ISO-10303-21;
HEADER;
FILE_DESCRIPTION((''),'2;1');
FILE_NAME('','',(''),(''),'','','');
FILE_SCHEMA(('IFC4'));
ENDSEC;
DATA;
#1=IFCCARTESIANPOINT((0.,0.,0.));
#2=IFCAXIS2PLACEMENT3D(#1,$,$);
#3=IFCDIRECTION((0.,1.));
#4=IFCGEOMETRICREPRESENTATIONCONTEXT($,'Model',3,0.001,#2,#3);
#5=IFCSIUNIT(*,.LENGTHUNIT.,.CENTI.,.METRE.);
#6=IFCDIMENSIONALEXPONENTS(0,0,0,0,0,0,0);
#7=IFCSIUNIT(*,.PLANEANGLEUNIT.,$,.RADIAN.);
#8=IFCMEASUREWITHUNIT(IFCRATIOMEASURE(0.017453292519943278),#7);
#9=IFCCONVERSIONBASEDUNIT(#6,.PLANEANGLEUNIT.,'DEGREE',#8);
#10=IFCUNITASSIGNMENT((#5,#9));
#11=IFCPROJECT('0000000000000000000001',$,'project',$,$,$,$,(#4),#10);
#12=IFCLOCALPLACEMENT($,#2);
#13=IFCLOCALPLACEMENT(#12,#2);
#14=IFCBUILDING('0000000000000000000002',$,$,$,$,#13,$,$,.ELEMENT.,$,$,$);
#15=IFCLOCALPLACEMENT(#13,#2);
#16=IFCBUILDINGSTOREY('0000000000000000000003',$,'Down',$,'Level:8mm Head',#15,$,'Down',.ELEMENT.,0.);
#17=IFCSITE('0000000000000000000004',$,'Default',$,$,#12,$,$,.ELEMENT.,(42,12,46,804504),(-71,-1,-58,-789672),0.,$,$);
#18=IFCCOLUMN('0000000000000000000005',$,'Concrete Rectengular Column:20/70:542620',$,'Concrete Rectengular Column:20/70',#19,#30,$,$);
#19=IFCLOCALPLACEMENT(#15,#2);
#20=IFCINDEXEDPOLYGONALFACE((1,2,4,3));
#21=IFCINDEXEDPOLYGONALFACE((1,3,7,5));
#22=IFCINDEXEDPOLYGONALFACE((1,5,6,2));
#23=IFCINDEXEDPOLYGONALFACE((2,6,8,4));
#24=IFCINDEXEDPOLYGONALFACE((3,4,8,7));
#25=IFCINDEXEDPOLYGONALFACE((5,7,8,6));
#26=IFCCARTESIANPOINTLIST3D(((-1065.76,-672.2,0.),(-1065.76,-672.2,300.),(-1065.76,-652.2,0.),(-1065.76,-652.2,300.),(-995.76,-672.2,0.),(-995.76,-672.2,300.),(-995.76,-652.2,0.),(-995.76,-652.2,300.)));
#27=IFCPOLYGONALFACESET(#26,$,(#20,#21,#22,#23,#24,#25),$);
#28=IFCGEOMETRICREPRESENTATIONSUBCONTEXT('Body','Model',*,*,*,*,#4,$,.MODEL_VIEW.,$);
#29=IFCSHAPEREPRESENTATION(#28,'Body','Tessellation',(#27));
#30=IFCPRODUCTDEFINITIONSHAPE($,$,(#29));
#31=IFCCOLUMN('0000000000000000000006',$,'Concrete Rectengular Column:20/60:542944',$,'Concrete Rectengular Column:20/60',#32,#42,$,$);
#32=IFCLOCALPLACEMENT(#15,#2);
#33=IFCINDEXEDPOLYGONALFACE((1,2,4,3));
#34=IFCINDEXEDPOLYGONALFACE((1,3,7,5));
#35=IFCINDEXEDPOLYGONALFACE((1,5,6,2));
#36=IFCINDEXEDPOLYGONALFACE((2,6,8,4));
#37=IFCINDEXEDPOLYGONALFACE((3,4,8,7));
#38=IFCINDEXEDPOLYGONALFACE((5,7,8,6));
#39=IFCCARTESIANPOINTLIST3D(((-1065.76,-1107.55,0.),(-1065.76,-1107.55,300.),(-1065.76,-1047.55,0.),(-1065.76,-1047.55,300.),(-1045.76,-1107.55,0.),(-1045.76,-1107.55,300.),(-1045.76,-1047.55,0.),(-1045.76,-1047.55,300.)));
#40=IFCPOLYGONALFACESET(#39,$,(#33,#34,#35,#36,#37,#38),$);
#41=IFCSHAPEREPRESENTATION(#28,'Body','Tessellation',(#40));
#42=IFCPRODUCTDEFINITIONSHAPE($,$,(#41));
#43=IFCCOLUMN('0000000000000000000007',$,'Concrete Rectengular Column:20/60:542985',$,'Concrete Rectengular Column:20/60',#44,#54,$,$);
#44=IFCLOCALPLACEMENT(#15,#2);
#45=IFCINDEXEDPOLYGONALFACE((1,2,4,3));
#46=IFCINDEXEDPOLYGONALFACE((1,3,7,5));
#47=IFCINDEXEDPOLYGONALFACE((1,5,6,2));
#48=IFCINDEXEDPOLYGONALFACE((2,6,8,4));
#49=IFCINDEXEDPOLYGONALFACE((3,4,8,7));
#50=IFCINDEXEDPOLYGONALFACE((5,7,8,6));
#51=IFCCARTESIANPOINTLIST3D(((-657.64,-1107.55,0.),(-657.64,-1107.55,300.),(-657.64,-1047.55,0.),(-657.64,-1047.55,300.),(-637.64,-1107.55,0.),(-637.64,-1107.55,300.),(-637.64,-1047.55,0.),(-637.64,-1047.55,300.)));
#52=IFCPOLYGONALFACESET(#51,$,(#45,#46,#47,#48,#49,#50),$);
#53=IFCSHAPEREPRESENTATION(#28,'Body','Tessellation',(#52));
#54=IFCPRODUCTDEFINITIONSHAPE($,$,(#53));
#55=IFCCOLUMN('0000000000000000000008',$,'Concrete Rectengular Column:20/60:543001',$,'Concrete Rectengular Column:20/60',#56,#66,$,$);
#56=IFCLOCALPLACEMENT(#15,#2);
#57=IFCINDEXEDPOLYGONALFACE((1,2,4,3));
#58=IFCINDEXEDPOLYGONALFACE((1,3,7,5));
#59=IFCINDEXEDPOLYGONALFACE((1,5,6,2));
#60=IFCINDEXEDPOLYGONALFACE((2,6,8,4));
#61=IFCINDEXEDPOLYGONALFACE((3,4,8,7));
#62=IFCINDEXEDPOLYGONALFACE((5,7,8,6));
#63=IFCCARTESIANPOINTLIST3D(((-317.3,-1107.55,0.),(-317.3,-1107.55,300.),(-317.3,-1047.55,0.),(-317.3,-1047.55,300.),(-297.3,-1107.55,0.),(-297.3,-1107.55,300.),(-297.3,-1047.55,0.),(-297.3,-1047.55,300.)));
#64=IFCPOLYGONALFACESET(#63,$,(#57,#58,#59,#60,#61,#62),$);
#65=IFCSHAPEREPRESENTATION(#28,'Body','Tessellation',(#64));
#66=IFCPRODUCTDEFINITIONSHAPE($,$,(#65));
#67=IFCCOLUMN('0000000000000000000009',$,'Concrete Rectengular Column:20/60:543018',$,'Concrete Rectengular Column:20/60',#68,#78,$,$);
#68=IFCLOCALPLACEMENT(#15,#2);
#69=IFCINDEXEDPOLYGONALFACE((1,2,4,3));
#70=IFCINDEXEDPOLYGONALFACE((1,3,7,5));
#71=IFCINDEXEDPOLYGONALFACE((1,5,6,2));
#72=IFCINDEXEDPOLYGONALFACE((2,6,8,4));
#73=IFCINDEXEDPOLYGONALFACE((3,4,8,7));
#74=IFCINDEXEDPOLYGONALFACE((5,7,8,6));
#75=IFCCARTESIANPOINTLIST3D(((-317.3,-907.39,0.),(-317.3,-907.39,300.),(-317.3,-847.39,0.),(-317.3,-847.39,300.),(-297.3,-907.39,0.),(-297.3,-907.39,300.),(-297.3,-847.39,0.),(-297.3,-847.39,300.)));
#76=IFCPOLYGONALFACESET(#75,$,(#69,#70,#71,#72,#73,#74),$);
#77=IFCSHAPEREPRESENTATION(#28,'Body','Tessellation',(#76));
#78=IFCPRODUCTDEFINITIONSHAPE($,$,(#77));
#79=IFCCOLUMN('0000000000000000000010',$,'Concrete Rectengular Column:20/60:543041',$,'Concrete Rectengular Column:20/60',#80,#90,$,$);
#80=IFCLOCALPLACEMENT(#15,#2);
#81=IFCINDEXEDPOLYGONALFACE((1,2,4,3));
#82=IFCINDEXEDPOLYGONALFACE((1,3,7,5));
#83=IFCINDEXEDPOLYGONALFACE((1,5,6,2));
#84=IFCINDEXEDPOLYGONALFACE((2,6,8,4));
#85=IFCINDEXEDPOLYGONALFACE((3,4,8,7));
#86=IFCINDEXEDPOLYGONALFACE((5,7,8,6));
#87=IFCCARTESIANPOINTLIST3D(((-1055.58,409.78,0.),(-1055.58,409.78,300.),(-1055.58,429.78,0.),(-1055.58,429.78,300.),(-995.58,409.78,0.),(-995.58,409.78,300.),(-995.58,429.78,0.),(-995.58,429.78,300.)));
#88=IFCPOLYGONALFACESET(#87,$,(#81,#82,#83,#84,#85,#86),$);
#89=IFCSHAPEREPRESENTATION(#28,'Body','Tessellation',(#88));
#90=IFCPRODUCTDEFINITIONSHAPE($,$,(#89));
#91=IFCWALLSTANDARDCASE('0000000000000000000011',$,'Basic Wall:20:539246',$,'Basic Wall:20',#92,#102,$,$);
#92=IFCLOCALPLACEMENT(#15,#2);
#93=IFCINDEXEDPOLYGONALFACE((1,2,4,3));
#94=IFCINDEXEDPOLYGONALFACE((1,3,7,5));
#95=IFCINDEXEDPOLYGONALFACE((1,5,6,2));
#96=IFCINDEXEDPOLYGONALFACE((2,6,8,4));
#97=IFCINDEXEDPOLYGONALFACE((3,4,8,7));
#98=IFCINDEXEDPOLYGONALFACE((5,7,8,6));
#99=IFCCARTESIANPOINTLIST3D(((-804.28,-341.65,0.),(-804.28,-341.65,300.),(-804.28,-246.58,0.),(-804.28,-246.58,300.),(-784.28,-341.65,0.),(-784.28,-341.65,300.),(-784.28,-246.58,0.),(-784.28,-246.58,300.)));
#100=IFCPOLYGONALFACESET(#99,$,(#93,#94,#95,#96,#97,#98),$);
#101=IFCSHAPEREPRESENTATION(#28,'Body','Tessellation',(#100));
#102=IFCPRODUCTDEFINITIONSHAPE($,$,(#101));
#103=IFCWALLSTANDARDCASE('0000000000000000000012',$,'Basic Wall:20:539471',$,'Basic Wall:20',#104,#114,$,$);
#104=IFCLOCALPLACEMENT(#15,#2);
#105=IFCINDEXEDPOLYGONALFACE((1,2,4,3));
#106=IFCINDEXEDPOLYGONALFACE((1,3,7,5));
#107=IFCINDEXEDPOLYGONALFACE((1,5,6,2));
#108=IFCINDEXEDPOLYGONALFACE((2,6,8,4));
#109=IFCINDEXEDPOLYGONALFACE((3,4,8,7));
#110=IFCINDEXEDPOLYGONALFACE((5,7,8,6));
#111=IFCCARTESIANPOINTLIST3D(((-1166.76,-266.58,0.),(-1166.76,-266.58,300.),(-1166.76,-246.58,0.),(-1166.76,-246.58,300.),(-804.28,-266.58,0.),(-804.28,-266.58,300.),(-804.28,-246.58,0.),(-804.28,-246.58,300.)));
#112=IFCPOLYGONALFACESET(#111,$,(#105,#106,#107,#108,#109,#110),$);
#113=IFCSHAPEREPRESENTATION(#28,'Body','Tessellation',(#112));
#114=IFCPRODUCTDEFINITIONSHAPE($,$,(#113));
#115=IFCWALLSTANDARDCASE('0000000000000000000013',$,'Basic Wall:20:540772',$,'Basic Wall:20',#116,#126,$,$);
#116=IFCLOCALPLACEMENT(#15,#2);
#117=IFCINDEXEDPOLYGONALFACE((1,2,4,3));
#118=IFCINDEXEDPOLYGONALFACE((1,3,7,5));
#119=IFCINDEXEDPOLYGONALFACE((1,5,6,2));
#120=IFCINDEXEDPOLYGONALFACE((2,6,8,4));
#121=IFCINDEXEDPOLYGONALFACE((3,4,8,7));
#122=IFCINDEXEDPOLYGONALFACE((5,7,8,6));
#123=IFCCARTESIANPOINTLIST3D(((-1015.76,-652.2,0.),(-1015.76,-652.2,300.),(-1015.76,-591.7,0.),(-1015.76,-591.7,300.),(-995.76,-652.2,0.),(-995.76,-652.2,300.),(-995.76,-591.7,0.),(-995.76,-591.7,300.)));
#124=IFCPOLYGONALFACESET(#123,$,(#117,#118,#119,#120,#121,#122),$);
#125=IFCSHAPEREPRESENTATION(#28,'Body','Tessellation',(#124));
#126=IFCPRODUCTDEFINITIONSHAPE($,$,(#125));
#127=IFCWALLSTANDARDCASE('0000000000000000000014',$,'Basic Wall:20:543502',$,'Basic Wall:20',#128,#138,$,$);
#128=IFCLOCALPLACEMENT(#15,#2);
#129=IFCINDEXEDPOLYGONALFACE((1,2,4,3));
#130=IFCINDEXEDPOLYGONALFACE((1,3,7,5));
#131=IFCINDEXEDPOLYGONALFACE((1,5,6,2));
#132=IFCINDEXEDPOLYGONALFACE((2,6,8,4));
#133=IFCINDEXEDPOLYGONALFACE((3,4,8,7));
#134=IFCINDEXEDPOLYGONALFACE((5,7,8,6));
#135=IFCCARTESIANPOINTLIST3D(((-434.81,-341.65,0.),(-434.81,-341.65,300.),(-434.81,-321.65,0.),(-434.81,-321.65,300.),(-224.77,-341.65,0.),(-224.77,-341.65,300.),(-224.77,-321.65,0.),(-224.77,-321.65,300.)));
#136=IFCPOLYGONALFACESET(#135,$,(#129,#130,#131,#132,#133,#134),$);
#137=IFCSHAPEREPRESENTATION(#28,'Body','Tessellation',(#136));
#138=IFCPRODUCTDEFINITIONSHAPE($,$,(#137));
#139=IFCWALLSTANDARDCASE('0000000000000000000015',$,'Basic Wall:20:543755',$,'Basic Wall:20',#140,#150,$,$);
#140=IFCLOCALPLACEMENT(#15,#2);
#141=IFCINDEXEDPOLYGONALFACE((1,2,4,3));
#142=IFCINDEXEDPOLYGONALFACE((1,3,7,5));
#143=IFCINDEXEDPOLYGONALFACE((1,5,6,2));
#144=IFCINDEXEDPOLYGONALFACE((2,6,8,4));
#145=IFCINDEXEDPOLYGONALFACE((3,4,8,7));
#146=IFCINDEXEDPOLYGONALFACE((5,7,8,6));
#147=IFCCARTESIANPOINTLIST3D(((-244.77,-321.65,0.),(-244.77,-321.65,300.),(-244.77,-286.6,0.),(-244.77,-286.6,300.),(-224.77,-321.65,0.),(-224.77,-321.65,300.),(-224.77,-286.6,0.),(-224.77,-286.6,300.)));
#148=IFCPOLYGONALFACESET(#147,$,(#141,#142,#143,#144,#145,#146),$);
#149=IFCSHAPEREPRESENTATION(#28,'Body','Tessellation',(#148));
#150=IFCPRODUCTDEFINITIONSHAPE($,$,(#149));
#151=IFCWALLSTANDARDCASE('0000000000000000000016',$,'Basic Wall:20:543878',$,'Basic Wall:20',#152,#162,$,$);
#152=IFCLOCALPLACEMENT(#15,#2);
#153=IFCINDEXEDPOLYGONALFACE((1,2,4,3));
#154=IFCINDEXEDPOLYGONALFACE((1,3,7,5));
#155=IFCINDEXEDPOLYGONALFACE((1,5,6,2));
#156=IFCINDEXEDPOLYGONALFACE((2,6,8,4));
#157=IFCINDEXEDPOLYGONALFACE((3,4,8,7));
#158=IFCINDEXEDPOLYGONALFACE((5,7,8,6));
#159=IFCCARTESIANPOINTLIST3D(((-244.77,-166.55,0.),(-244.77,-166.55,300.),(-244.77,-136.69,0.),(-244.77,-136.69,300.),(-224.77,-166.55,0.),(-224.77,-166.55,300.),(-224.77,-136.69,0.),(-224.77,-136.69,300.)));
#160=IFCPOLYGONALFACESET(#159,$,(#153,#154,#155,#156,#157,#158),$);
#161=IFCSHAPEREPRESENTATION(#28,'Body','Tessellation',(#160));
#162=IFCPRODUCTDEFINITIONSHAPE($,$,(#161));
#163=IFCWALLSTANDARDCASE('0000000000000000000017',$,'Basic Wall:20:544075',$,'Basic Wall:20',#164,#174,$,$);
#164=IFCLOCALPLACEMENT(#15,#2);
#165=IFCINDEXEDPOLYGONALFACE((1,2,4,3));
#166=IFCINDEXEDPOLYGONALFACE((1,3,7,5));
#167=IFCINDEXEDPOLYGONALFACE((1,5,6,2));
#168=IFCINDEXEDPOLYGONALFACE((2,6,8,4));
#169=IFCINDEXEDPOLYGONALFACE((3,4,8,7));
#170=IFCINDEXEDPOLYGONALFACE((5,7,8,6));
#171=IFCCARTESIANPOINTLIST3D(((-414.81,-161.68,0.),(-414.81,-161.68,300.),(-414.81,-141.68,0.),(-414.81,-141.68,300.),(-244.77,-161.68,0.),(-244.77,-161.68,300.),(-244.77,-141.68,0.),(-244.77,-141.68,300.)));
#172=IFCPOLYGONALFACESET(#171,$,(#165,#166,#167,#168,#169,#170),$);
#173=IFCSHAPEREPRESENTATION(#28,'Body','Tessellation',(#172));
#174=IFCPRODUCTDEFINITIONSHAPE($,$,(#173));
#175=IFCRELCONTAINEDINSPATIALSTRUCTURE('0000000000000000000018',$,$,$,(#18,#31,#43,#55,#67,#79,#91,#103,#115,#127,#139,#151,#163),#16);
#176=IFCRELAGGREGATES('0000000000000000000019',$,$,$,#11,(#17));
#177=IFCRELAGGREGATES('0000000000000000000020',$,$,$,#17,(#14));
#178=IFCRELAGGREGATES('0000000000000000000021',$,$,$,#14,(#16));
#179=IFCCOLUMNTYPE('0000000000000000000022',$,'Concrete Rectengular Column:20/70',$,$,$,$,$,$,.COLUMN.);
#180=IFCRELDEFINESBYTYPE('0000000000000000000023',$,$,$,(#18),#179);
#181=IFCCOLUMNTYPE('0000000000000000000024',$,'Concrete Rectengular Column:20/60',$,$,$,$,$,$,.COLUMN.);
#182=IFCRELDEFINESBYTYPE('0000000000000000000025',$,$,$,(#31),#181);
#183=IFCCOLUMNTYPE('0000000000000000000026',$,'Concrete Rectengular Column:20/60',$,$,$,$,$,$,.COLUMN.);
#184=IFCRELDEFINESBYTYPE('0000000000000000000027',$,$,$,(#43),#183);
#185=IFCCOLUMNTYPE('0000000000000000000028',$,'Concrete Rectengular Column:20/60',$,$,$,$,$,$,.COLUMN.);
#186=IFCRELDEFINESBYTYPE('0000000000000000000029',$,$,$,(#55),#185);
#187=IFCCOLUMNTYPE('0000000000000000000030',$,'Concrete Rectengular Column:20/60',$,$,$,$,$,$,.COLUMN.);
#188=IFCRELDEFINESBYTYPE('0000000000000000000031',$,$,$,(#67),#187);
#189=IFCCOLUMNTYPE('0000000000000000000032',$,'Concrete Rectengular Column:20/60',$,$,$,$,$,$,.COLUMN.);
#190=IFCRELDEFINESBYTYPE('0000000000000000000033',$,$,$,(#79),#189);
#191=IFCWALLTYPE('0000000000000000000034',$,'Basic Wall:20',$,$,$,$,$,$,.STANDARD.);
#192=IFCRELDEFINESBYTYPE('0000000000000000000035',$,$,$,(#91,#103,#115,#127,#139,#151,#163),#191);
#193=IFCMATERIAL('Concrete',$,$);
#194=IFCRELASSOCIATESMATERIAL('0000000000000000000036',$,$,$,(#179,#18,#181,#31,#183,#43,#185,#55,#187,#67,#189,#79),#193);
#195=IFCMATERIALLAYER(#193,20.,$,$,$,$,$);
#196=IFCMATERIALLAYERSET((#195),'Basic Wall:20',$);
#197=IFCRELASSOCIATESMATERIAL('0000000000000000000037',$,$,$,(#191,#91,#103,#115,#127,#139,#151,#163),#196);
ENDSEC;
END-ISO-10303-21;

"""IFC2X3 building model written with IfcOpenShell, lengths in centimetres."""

from ifc_helpers import new_model, entity, si_unit, converted_unit, direction, frame, frame_2d, origin, origin_2d_with_axis, place, context, subcontext, project, spatial, rectangle, extrude, source, transform, mapped, material, layer, layer_set, layer_usage, type_object, type_shapes, element, save


model = new_model("IFC2X3")

# Units and contexts
model_context = context("Model", 3, precision=0.001, world=origin(), true_north=direction((0.0, 1.0)))
body_context = subcontext(model_context, "Body", "Model", "MODEL_VIEW")
ifc_project = project(units=[si_unit("LENGTHUNIT", "METRE", prefix="CENTI"), converted_unit("PLANEANGLEUNIT", "DEGREE", entity("IfcRatioMeasure", 0.017453292519943278), si_unit("PLANEANGLEUNIT", "RADIAN"), dimensions=[0, 0, 0, 0, 0, 0, 0])], contexts=[model_context])

# Site, building, storey
site_placement = place(None, origin())
site = spatial("IfcSite", under=ifc_project, at=site_placement, Name="Default", CompositionType="ELEMENT", RefLatitude=(42, 12, 46, 804504), RefLongitude=(-71, -1, -58, -789672), RefElevation=0.0)
building_placement = place(site_placement, origin())
building = spatial("IfcBuilding", under=site, at=building_placement, CompositionType="ELEMENT")
storey_placement = place(building_placement, origin())
storey = spatial("IfcBuildingStorey", under=building, at=storey_placement, Name="Down", ObjectType="Level:8mm Head", LongName="Down", CompositionType="ELEMENT", Elevation=0.0)

# Columns
ifc_material = material(Name="Concrete")
column_type_1 = type_object("IfcColumnType", Name="Concrete Rectengular Column:20/70", PredefinedType="COLUMN", material=ifc_material)
shared_shape_1 = source(origin(), body_context, "Body", "SweptSolid", [
    extrude(rectangle(XDim=20.0, YDim=70.0, at=origin_2d_with_axis()), frame((-1030.76, -662.2, 0.0), z_axis=(0.0, 0.0, 1.0), x_axis=(0.0, -1.0, 0.0)), (0.0, 0.0, 1.0), 300.0),
])
type_shapes(column_type_1, [shared_shape_1])
column_1_placement = place(storey_placement, origin())
element("IfcColumn", 1, at=column_1_placement, inside=storey, type_object=column_type_1, material=ifc_material, Name="Concrete Rectengular Column:20/70:542620", ObjectType="Concrete Rectengular Column:20/70", context=body_context, shape_type="MappedRepresentation", body=[
    mapped(shared_shape_1, transform((0.0, 0.0, 0.0), scale=1.0)),
])
column_type_2 = type_object("IfcColumnType", Name="Concrete Rectengular Column:20/60", PredefinedType="COLUMN", material=ifc_material)
shared_shape_2 = source(origin(), body_context, "Body", "SweptSolid", [
    extrude(rectangle(XDim=60.0, YDim=20.0, at=frame_2d((0.0, 0.0), x_axis=(1.0, 0.0))), frame((-1055.76, -1077.55, 0.0), z_axis=(0.0, 0.0, 1.0), x_axis=(0.0, -1.0, 0.0)), (0.0, 0.0, 1.0), 300.0),
])
type_shapes(column_type_2, [shared_shape_2])
column_2_placement = place(storey_placement, origin())
element("IfcColumn", 2, at=column_2_placement, inside=storey, type_object=column_type_2, material=ifc_material, Name="Concrete Rectengular Column:20/60:542944", ObjectType="Concrete Rectengular Column:20/60", context=body_context, shape_type="MappedRepresentation", body=[
    mapped(shared_shape_2, transform((0.0, 0.0, 0.0), scale=1.0)),
])
column_type_3 = type_object("IfcColumnType", Name="Concrete Rectengular Column:20/60", PredefinedType="COLUMN", material=ifc_material)
shared_shape_3 = source(origin(), body_context, "Body", "SweptSolid", [
    extrude(rectangle(XDim=60.0, YDim=20.0, at=frame_2d((0.0, 0.0), x_axis=(1.0, 0.0))), frame((-647.64, -1077.55, 0.0), z_axis=(0.0, 0.0, 1.0), x_axis=(0.0, -1.0, 0.0)), (0.0, 0.0, 1.0), 300.0),
])
type_shapes(column_type_3, [shared_shape_3])
column_3_placement = place(storey_placement, origin())
element("IfcColumn", 3, at=column_3_placement, inside=storey, type_object=column_type_3, material=ifc_material, Name="Concrete Rectengular Column:20/60:542985", ObjectType="Concrete Rectengular Column:20/60", context=body_context, shape_type="MappedRepresentation", body=[
    mapped(shared_shape_3, transform((0.0, 0.0, 0.0), scale=1.0)),
])
column_type_4 = type_object("IfcColumnType", Name="Concrete Rectengular Column:20/60", PredefinedType="COLUMN", material=ifc_material)
shared_shape_4 = source(origin(), body_context, "Body", "SweptSolid", [
    extrude(rectangle(XDim=60.0, YDim=20.0, at=frame_2d((0.0, 0.0), x_axis=(1.0, 0.0))), frame((-307.3, -1077.55, 0.0), z_axis=(0.0, 0.0, 1.0), x_axis=(0.0, -1.0, 0.0)), (0.0, 0.0, 1.0), 300.0),
])
type_shapes(column_type_4, [shared_shape_4])
column_4_placement = place(storey_placement, origin())
element("IfcColumn", 4, at=column_4_placement, inside=storey, type_object=column_type_4, material=ifc_material, Name="Concrete Rectengular Column:20/60:543001", ObjectType="Concrete Rectengular Column:20/60", context=body_context, shape_type="MappedRepresentation", body=[
    mapped(shared_shape_4, transform((0.0, 0.0, 0.0), scale=1.0)),
])
column_type_5 = type_object("IfcColumnType", Name="Concrete Rectengular Column:20/60", PredefinedType="COLUMN", material=ifc_material)
shared_shape_5 = source(origin(), body_context, "Body", "SweptSolid", [
    extrude(rectangle(XDim=60.0, YDim=20.0, at=origin_2d_with_axis()), frame((-307.3, -877.39, 0.0), z_axis=(0.0, 0.0, 1.0), x_axis=(0.0, -1.0, 0.0)), (0.0, 0.0, 1.0), 300.0),
])
type_shapes(column_type_5, [shared_shape_5])
column_5_placement = place(storey_placement, origin())
element("IfcColumn", 5, at=column_5_placement, inside=storey, type_object=column_type_5, material=ifc_material, Name="Concrete Rectengular Column:20/60:543018", ObjectType="Concrete Rectengular Column:20/60", context=body_context, shape_type="MappedRepresentation", body=[
    mapped(shared_shape_5, transform((0.0, 0.0, 0.0), scale=1.0)),
])
column_type_6 = type_object("IfcColumnType", Name="Concrete Rectengular Column:20/60", PredefinedType="COLUMN", material=ifc_material)
shared_shape_6 = source(origin(), body_context, "Body", "SweptSolid", [
    extrude(rectangle(XDim=20.0, YDim=60.0, at=frame_2d((0.0, 0.0), x_axis=(1.0, 0.0))), frame((-1025.58, 419.78, 0.0), z_axis=(0.0, 0.0, 1.0), x_axis=(0.0, -1.0, 0.0)), (0.0, 0.0, 1.0), 300.0),
])
type_shapes(column_type_6, [shared_shape_6])
column_6_placement = place(storey_placement, origin())
element("IfcColumn", 6, at=column_6_placement, inside=storey, type_object=column_type_6, material=ifc_material, Name="Concrete Rectengular Column:20/60:543041", ObjectType="Concrete Rectengular Column:20/60", context=body_context, shape_type="MappedRepresentation", body=[
    mapped(shared_shape_6, transform((0.0, 0.0, 0.0), scale=1.0)),
])

# Walls
ifc_layer_1 = layer(ifc_material, 20.0)
ifc_layer_set_1 = layer_set([ifc_layer_1], Name="Basic Wall:20")
ifc_layer_usage_1 = layer_usage(ifc_layer_set_1, "AXIS2", "NEGATIVE", 10.0)
wall_type_1 = type_object("IfcWallType", Name="Basic Wall:20", PredefinedType="STANDARD", material=ifc_layer_set_1)
wall_1_placement = place(storey_placement, frame((-794.28, -341.65, 0.0), z_axis=(0.0, 0.0, 1.0), x_axis=(0.0, 1.0, 0.0)))
element("IfcWallStandardCase", 7, at=wall_1_placement, inside=storey, type_object=wall_type_1, material=ifc_layer_usage_1, Name="Basic Wall:20:539246", ObjectType="Basic Wall:20", context=body_context, shape_type="SweptSolid", body=[
    extrude(rectangle(XDim=95.07, YDim=20.0, at=frame_2d((47.53, 0.0), x_axis=(-1.0, 0.0))), origin(), (0.0, 0.0, 1.0), 300.0),
])
ifc_layer_usage_2 = layer_usage(ifc_layer_set_1, "AXIS2", "POSITIVE", -10.0)
wall_2_placement = place(storey_placement, frame((-804.28, -256.58, 0.0), z_axis=(0.0, 0.0, 1.0), x_axis=(-1.0, 0.0, 0.0)))
element("IfcWallStandardCase", 8, at=wall_2_placement, inside=storey, type_object=wall_type_1, material=ifc_layer_usage_2, Name="Basic Wall:20:539471", ObjectType="Basic Wall:20", context=body_context, shape_type="SweptSolid", body=[
    extrude(rectangle(XDim=362.48, YDim=20.0, at=frame_2d((181.24, 0.0), x_axis=(-1.0, 0.0))), origin(), (0.0, 0.0, 1.0), 300.0),
])
ifc_layer_usage_3 = layer_usage(ifc_layer_set_1, "AXIS2", "NEGATIVE", 10.0)
wall_3_placement = place(storey_placement, frame((-1005.76, -591.7, 0.0), z_axis=(0.0, 0.0, 1.0), x_axis=(0.0, -1.0, 0.0)))
element("IfcWallStandardCase", 9, at=wall_3_placement, inside=storey, type_object=wall_type_1, material=ifc_layer_usage_3, Name="Basic Wall:20:540772", ObjectType="Basic Wall:20", context=body_context, shape_type="SweptSolid", body=[
    extrude(rectangle(XDim=60.5, YDim=20.0, at=frame_2d((30.25, 0.0), x_axis=(-1.0, 0.0))), origin(), (0.0, 0.0, 1.0), 300.0),
])
ifc_layer_usage_4 = layer_usage(ifc_layer_set_1, "AXIS2", "POSITIVE", -10.0)
wall_4_placement = place(storey_placement, frame((-434.81, -331.65, 0.0)))
element("IfcWallStandardCase", 10, at=wall_4_placement, inside=storey, type_object=wall_type_1, material=ifc_layer_usage_4, Name="Basic Wall:20:543502", ObjectType="Basic Wall:20", context=body_context, shape_type="SweptSolid", body=[
    extrude(rectangle(XDim=210.04, YDim=20.0, at=frame_2d((105.02, 0.0), x_axis=(-1.0, 0.0))), origin(), (0.0, 0.0, 1.0), 300.0),
])
ifc_layer_usage_5 = layer_usage(ifc_layer_set_1, "AXIS2", "POSITIVE", -10.0)
wall_5_placement = place(storey_placement, frame((-234.77, -321.65, 0.0), z_axis=(0.0, 0.0, 1.0), x_axis=(0.0, 1.0, 0.0)))
element("IfcWallStandardCase", 11, at=wall_5_placement, inside=storey, type_object=wall_type_1, material=ifc_layer_usage_5, Name="Basic Wall:20:543755", ObjectType="Basic Wall:20", context=body_context, shape_type="SweptSolid", body=[
    extrude(rectangle(XDim=35.05, YDim=20.0, at=frame_2d((17.52, 0.0), x_axis=(-1.0, 0.0))), origin(), (0.0, 0.0, 1.0), 300.0),
])
ifc_layer_usage_6 = layer_usage(ifc_layer_set_1, "AXIS2", "POSITIVE", -10.0)
wall_6_placement = place(storey_placement, frame((-234.77, -166.55, 0.0), z_axis=(0.0, 0.0, 1.0), x_axis=(0.0, 1.0, 0.0)))
element("IfcWallStandardCase", 12, at=wall_6_placement, inside=storey, type_object=wall_type_1, material=ifc_layer_usage_6, Name="Basic Wall:20:543878", ObjectType="Basic Wall:20", context=body_context, shape_type="SweptSolid", body=[
    extrude(rectangle(XDim=29.85, YDim=20.0, at=frame_2d((14.93, 0.0), x_axis=(-1.0, 0.0))), origin(), (0.0, 0.0, 1.0), 300.0),
])
ifc_layer_usage_7 = layer_usage(ifc_layer_set_1, "AXIS2", "NEGATIVE", 10.0)
wall_7_placement = place(storey_placement, frame((-244.77, -151.68, 0.0), z_axis=(0.0, 0.0, 1.0), x_axis=(-1.0, 0.0, 0.0)))
element("IfcWallStandardCase", 13, at=wall_7_placement, inside=storey, type_object=wall_type_1, material=ifc_layer_usage_7, Name="Basic Wall:20:544075", ObjectType="Basic Wall:20", context=body_context, shape_type="SweptSolid", body=[
    extrude(rectangle(XDim=170.04, YDim=20.0, at=frame_2d((85.02, 0.0), x_axis=(-1.0, 0.0))), origin(), (0.0, 0.0, 1.0), 300.0),
])

save(model, "model.ifc")
